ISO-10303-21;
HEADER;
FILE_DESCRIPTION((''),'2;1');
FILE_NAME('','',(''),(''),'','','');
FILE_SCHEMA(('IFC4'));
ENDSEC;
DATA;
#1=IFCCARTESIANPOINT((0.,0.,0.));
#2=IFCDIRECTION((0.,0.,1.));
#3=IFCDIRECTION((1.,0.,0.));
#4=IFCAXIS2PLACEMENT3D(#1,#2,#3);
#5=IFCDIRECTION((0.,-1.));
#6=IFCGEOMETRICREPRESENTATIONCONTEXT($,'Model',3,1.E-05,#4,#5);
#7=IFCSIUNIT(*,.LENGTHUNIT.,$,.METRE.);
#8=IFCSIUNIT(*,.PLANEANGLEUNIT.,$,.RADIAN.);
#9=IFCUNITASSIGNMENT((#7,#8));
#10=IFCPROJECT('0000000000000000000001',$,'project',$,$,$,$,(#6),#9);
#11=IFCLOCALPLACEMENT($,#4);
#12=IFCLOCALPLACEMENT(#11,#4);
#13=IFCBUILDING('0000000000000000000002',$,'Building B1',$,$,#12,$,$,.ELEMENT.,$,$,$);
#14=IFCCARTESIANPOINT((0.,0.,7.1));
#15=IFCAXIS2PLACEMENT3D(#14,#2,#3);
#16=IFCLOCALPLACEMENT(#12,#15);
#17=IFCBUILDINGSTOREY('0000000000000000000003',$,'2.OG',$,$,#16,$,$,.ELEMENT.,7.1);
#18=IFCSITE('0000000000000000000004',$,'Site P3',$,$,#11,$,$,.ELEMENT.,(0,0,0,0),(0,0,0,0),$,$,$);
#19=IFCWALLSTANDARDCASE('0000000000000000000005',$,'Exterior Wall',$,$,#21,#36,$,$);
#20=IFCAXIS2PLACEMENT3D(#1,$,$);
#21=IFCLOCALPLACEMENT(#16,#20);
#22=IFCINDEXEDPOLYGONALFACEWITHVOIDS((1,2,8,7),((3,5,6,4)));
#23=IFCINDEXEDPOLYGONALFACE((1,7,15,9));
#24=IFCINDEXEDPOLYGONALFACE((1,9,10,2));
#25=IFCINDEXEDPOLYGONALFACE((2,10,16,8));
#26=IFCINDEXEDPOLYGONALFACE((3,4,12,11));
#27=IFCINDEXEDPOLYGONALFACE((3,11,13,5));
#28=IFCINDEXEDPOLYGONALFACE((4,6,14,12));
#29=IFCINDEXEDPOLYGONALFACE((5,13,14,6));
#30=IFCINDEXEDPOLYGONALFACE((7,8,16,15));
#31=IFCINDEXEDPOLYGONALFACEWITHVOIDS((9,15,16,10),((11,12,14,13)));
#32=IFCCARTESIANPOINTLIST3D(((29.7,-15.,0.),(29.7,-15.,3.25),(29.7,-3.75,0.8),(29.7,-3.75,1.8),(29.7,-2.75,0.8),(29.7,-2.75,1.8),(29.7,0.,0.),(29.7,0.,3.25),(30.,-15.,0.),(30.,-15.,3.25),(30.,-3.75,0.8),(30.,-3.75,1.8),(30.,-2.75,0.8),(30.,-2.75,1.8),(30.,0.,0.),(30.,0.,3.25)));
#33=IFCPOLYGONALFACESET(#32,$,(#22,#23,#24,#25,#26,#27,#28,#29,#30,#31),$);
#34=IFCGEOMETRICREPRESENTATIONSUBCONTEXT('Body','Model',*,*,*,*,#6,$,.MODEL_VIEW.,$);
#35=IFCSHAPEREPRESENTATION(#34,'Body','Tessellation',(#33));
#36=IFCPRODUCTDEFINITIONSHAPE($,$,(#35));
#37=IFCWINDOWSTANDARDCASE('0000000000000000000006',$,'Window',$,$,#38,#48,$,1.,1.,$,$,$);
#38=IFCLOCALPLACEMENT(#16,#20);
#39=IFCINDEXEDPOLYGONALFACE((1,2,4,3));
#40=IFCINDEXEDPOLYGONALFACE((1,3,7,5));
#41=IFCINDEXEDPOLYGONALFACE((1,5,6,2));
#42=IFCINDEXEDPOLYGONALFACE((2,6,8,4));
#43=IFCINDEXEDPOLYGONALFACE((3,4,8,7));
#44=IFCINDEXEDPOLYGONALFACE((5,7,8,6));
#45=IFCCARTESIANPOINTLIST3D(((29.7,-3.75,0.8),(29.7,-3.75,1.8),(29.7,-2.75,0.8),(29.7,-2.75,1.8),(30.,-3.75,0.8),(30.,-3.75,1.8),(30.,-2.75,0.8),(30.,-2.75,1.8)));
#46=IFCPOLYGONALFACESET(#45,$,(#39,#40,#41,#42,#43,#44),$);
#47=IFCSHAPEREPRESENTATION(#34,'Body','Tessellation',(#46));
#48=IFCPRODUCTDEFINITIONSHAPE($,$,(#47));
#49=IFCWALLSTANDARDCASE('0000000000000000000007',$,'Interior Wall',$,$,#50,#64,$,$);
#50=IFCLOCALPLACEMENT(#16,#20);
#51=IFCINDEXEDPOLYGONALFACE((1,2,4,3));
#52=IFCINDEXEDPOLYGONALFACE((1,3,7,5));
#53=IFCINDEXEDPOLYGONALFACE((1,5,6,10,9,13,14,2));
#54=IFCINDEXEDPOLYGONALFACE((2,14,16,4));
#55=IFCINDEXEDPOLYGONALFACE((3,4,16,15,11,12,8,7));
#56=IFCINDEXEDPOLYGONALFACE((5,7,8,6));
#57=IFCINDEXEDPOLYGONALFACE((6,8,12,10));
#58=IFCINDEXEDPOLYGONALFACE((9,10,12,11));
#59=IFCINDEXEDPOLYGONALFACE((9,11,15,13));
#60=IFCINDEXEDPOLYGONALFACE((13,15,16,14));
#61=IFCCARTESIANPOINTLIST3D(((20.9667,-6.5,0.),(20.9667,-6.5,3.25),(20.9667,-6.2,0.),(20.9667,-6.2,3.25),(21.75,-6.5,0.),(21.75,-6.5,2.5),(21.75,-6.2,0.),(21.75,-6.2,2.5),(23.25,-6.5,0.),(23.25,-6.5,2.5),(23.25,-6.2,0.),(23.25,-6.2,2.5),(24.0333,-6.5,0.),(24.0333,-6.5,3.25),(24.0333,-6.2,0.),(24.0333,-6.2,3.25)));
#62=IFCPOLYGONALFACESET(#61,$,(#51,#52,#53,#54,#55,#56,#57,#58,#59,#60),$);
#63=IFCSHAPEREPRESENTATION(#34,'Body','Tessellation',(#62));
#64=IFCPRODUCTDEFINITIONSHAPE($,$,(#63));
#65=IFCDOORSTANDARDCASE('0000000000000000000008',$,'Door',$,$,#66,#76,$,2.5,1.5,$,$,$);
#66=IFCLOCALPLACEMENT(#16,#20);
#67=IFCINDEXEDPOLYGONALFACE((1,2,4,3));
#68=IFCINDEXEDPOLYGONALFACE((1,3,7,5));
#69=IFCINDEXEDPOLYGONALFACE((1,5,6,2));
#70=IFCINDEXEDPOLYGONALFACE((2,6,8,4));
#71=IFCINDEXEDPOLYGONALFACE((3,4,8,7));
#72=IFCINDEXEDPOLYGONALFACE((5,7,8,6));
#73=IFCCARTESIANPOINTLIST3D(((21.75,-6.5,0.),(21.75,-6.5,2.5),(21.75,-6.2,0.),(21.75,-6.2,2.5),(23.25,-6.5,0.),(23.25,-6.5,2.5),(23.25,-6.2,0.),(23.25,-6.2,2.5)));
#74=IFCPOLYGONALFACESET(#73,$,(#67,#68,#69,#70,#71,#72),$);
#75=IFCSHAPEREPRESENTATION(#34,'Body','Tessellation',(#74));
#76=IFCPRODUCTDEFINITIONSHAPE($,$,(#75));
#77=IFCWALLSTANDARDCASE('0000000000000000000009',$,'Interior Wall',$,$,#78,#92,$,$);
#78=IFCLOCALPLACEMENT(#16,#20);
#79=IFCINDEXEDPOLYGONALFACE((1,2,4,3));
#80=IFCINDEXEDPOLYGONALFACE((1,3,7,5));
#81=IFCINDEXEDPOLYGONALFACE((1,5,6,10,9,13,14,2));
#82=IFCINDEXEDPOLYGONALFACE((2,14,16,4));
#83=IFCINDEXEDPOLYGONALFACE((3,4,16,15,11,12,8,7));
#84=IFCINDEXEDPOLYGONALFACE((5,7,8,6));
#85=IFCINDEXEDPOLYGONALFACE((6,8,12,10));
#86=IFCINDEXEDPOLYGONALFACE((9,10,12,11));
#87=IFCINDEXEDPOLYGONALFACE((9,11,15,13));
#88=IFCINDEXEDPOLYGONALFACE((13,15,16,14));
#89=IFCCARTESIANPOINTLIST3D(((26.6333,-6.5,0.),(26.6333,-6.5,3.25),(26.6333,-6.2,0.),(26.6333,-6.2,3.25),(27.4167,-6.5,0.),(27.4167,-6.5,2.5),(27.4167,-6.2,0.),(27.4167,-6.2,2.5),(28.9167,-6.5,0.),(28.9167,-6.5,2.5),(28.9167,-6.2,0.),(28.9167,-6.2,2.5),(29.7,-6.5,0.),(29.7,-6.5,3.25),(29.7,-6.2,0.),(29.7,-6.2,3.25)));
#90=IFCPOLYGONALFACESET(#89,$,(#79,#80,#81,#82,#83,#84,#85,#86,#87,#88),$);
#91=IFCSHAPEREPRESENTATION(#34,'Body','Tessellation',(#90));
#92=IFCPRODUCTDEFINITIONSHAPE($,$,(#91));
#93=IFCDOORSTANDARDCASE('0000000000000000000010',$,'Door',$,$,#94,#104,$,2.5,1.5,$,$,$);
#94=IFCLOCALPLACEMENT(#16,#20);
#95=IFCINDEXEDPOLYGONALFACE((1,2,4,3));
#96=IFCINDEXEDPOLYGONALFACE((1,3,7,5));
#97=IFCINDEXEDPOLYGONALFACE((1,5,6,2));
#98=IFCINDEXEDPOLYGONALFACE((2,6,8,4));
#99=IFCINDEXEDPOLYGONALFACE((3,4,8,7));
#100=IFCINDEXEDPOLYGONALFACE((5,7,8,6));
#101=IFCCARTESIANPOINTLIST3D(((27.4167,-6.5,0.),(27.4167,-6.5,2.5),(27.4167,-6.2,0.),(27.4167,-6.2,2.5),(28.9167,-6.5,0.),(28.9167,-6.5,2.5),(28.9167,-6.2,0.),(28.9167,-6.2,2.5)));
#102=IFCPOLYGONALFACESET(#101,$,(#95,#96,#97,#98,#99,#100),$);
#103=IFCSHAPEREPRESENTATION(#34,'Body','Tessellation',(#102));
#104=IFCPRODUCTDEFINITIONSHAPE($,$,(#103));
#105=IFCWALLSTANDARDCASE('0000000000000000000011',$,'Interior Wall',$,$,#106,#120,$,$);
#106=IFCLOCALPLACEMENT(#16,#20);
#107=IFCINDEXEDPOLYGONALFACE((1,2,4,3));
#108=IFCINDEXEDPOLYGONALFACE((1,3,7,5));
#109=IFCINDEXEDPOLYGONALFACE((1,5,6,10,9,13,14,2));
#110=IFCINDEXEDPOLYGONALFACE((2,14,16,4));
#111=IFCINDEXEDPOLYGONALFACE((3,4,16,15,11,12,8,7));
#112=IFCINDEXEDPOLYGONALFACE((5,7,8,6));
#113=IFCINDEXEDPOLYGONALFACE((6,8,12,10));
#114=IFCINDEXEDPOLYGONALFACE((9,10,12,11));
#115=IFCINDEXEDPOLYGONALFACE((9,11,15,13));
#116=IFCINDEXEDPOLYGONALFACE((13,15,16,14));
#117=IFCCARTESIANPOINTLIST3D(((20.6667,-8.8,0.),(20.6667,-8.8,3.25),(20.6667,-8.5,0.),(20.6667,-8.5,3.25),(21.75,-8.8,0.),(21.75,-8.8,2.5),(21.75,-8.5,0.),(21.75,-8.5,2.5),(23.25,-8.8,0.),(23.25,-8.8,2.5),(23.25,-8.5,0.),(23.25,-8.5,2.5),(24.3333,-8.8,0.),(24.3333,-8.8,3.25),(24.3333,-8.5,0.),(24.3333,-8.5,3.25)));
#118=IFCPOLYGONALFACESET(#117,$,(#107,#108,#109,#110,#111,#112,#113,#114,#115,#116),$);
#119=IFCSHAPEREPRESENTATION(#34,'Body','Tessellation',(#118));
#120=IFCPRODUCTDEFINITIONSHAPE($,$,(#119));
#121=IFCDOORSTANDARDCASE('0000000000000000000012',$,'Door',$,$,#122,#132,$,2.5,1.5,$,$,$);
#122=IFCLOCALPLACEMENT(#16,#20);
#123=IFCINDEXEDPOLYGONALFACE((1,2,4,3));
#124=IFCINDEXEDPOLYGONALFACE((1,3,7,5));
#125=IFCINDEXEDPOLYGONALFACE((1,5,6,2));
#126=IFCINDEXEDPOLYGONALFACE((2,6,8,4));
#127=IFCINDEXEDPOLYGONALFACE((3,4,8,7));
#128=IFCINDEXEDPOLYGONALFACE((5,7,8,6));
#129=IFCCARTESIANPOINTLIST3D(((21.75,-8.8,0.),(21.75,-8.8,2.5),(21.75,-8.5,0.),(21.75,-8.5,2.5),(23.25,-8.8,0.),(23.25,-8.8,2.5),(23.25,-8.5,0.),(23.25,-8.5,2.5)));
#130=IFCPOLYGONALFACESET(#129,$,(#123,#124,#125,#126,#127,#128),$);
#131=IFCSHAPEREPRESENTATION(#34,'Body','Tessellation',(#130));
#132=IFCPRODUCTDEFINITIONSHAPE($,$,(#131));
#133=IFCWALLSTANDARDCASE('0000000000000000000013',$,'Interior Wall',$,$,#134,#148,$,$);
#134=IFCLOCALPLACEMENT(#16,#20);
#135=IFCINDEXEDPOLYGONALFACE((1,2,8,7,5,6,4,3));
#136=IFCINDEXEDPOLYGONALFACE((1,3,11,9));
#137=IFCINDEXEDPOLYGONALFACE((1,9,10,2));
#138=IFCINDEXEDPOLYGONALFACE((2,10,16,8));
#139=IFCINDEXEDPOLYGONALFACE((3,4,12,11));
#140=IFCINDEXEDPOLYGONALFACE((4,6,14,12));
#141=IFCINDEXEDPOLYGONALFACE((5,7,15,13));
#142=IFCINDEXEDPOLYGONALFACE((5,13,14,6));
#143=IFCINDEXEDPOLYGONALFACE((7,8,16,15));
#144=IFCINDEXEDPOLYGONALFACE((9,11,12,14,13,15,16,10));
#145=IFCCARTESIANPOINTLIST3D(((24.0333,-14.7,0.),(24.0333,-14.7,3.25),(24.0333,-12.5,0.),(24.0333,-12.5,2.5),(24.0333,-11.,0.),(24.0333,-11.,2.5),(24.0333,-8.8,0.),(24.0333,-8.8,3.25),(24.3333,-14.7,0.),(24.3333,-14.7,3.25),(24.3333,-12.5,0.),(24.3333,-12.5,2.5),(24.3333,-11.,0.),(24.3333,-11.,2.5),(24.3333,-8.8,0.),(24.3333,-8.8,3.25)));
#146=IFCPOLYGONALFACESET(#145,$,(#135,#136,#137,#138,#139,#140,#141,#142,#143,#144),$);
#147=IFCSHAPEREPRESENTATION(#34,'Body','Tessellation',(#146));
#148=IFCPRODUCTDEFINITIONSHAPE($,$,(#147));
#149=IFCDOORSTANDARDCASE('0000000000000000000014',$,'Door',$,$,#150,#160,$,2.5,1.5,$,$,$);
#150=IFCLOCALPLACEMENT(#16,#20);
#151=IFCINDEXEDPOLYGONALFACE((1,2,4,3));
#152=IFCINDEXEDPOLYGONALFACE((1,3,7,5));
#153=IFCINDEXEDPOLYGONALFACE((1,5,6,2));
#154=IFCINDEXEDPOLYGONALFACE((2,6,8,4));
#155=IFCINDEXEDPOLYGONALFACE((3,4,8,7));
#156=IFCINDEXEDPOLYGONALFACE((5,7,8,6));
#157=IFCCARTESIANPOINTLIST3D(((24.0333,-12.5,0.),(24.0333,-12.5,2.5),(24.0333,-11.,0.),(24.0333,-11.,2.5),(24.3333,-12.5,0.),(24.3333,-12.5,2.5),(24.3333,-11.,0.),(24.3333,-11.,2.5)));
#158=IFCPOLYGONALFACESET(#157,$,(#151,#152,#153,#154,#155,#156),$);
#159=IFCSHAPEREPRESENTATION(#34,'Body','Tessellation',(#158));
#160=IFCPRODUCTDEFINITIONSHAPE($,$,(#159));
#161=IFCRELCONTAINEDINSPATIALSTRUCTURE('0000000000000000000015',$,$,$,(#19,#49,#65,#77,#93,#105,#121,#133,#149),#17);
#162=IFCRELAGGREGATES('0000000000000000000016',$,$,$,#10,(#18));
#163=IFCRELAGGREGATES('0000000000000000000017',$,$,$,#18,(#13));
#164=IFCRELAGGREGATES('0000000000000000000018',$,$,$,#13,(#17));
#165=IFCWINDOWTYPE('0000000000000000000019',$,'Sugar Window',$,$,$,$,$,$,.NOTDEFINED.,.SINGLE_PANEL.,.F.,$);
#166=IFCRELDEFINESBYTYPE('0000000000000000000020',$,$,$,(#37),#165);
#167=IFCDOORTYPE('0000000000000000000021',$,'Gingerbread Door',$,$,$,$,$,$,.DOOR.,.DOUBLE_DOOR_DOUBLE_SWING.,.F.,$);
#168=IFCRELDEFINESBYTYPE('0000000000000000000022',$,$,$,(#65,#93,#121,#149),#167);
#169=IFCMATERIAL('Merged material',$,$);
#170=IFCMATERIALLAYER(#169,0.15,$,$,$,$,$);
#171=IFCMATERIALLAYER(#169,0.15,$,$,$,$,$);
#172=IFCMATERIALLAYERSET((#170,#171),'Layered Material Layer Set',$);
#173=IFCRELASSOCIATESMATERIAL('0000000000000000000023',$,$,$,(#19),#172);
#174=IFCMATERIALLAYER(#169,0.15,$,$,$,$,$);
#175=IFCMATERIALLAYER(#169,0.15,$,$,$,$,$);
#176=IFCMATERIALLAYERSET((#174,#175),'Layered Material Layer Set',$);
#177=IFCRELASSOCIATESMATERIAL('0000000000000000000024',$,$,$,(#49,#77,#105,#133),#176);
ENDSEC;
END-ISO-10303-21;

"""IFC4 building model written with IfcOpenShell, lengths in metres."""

from ifc_helpers import new_model, si_unit, direction, frame, origin_with_axes, place, context, subcontext, project, spatial, polyline, outline, extrude, source, transform, mapped, material, layer, layer_set, layer_usage, type_object, element, fill, save


model = new_model("IFC4")

# Units and contexts
model_context = context("Model", 3, precision=1e-05, world=origin_with_axes(), true_north=direction((0.0, -1.0)))
body_context = subcontext(model_context, "Body", "Model", "MODEL_VIEW")
ifc_project = project(units=[si_unit("LENGTHUNIT", "METRE"), si_unit("PLANEANGLEUNIT", "RADIAN")], contexts=[model_context])

# Site, building, storey
site_placement = place(None, origin_with_axes())
site = spatial("IfcSite", under=ifc_project, at=site_placement, Name="Site P3", CompositionType="ELEMENT", RefLatitude=(0, 0, 0, 0), RefLongitude=(0, 0, 0, 0))
building_placement = place(site_placement, origin_with_axes())
building = spatial("IfcBuilding", under=site, at=building_placement, Name="Building B1", CompositionType="ELEMENT")
storey_placement = place(building_placement, frame((0.0, 0.0, 7.1), z_axis=(0.0, 0.0, 1.0), x_axis=(1.0, 0.0, 0.0)))
storey = spatial("IfcBuildingStorey", under=building, at=storey_placement, Name="2.OG", CompositionType="ELEMENT", Elevation=7.1)

# Wall, opening, window
ifc_material = material(Name="Merged material")
ifc_layer_1 = layer(ifc_material, 0.15)
ifc_layer_2 = layer(ifc_material, 0.15)
ifc_layer_set_1 = layer_set([ifc_layer_1, ifc_layer_2], Name="Layered Material Layer Set")
ifc_layer_usage_1 = layer_usage(ifc_layer_set_1, "AXIS2", "POSITIVE", -0.15)
wall_1_placement = place(storey_placement, frame((29.85, -15.0, 0.0), z_axis=(0.0, 0.0, 1.0), x_axis=(0.0, 1.0, 0.0)))
wall_1 = element("IfcWallStandardCase", 1, at=wall_1_placement, inside=storey, material=ifc_layer_usage_1, Name="Exterior Wall", context=body_context, shape_type="SweptSolid", body=[
    extrude(outline(polyline([(0.0, 0.15), (15.0, 0.15), (15.0, -0.15), (0.0, -0.15), (0.0, 0.15)])), origin_with_axes(), (0.0, 0.0, 1.0), 3.25),
])
opening_1_placement = place(wall_1_placement, frame((11.25, 0.0, 0.8), z_axis=(0.0, 0.0, 1.0), x_axis=(1.0, 0.0, 0.0)))
opening_1 = element("IfcOpeningStandardCase", 2, at=opening_1_placement, cuts=wall_1, context=body_context, shape_type="SweptSolid", body=[
    extrude(outline(polyline([(0.0, 0.0), (0.0, 1.0), (1.0, 1.0), (1.0, 0.0), (0.0, 0.0)])), frame((0.0, -0.15, 0.0), z_axis=(0.0, 1.0, 0.0), x_axis=(0.0, 0.0, 1.0)), (0.0, 0.0, 1.0), 0.3),
])
window_type = type_object("IfcWindowType", Name="Sugar Window", ParameterTakesPrecedence=False, PartitioningType="SINGLE_PANEL", PredefinedType="NOTDEFINED")
shared_shape_1 = source(origin_with_axes(), body_context, "Body", "SweptSolid", [
    extrude(outline(polyline([(0.0, 0.0), (0.0, 1.0), (1.0, 1.0), (1.0, 0.0), (0.0, 0.0)])), frame((0.0, -0.15, 0.0), z_axis=(0.0, 1.0, 0.0), x_axis=(0.0, 0.0, 1.0)), (0.0, 0.0, 1.0), 0.3),
])
window_placement = place(opening_1_placement, origin_with_axes())
window = element("IfcWindowStandardCase", 3, at=window_placement, type_object=window_type, Name="Window", OverallHeight=1.0, OverallWidth=1.0, context=body_context, shape_type="MappedRepresentation", body=[
    mapped(shared_shape_1, transform((0.0, 0.0, 0.0))),
])
fill(opening_1, window)

# Walls, openings, doors
ifc_layer_3 = layer(ifc_material, 0.15)
ifc_layer_4 = layer(ifc_material, 0.15)
ifc_layer_set_2 = layer_set([ifc_layer_3, ifc_layer_4], Name="Layered Material Layer Set")
ifc_layer_usage_2 = layer_usage(ifc_layer_set_2, "AXIS2", "POSITIVE", -0.15)
wall_2_placement = place(storey_placement, frame((20.9667, -6.35, 0.0), z_axis=(0.0, 0.0, 1.0), x_axis=(1.0, 0.0, 0.0)))
wall_2 = element("IfcWallStandardCase", 4, at=wall_2_placement, inside=storey, material=ifc_layer_usage_2, Name="Interior Wall", context=body_context, shape_type="SweptSolid", body=[
    extrude(outline(polyline([(0.0, 0.15), (3.0667, 0.15), (3.0667, -0.15), (0.0, -0.15), (0.0, 0.15)])), origin_with_axes(), (0.0, 0.0, 1.0), 3.25),
])
opening_2_placement = place(wall_2_placement, frame((0.7833, 0.0, 0.0), z_axis=(0.0, 0.0, 1.0), x_axis=(1.0, 0.0, 0.0)))
opening_2 = element("IfcOpeningStandardCase", 5, at=opening_2_placement, cuts=wall_2, context=body_context, shape_type="SweptSolid", body=[
    extrude(outline(polyline([(0.0, 0.0), (0.0, 1.5), (2.5, 1.5), (2.5, 0.0), (0.0, 0.0)])), frame((0.0, -0.15, 0.0), z_axis=(0.0, 1.0, 0.0), x_axis=(0.0, 0.0, 1.0)), (0.0, 0.0, 1.0), 0.3),
])
door_type = type_object("IfcDoorType", Name="Gingerbread Door", OperationType="DOUBLE_DOOR_DOUBLE_SWING", ParameterTakesPrecedence=False, PredefinedType="DOOR")
shared_shape_2 = source(origin_with_axes(), body_context, "Body", "SweptSolid", [
    extrude(outline(polyline([(0.0, 0.0), (0.0, 1.5), (2.5, 1.5), (2.5, 0.0), (0.0, 0.0)])), frame((0.0, -0.15, 0.0), z_axis=(0.0, 1.0, 0.0), x_axis=(0.0, 0.0, 1.0)), (0.0, 0.0, 1.0), 0.3),
])
door_1_placement = place(opening_2_placement, origin_with_axes())
door_1 = element("IfcDoorStandardCase", 6, at=door_1_placement, inside=storey, type_object=door_type, Name="Door", OverallHeight=2.5, OverallWidth=1.5, context=body_context, shape_type="MappedRepresentation", body=[
    mapped(shared_shape_2, transform((0.0, 0.0, 0.0))),
])
fill(opening_2, door_1)
wall_3_placement = place(storey_placement, frame((26.6333, -6.35, 0.0), z_axis=(0.0, 0.0, 1.0), x_axis=(1.0, 0.0, 0.0)))
wall_3 = element("IfcWallStandardCase", 7, at=wall_3_placement, inside=storey, material=ifc_layer_usage_2, Name="Interior Wall", context=body_context, shape_type="SweptSolid", body=[
    extrude(outline(polyline([(0.0, 0.15), (3.0667, 0.15), (3.0667, -0.15), (0.0, -0.15), (0.0, 0.15)])), origin_with_axes(), (0.0, 0.0, 1.0), 3.25),
])
opening_3_placement = place(wall_3_placement, frame((0.7833, 0.0, 0.0), z_axis=(0.0, 0.0, 1.0), x_axis=(1.0, 0.0, 0.0)))
opening_3 = element("IfcOpeningStandardCase", 8, at=opening_3_placement, cuts=wall_3, context=body_context, shape_type="SweptSolid", body=[
    extrude(outline(polyline([(0.0, 0.0), (0.0, 1.5), (2.5, 1.5), (2.5, 0.0), (0.0, 0.0)])), frame((0.0, -0.15, 0.0), z_axis=(0.0, 1.0, 0.0), x_axis=(0.0, 0.0, 1.0)), (0.0, 0.0, 1.0), 0.3),
])
door_2_placement = place(opening_3_placement, origin_with_axes())
door_2 = element("IfcDoorStandardCase", 9, at=door_2_placement, inside=storey, type_object=door_type, Name="Door", OverallHeight=2.5, OverallWidth=1.5, context=body_context, shape_type="MappedRepresentation", body=[
    mapped(shared_shape_2, transform((0.0, 0.0, 0.0))),
])
fill(opening_3, door_2)
wall_4_placement = place(storey_placement, frame((20.6667, -8.65, 0.0), z_axis=(0.0, 0.0, 1.0), x_axis=(1.0, 0.0, 0.0)))
wall_4 = element("IfcWallStandardCase", 10, at=wall_4_placement, inside=storey, material=ifc_layer_usage_2, Name="Interior Wall", context=body_context, shape_type="SweptSolid", body=[
    extrude(outline(polyline([(0.0, 0.15), (3.6667, 0.15), (3.6667, -0.15), (0.0, -0.15), (0.0, 0.15)])), origin_with_axes(), (0.0, 0.0, 1.0), 3.25),
])
opening_4_placement = place(wall_4_placement, frame((1.0833, 0.0, 0.0), z_axis=(0.0, 0.0, 1.0), x_axis=(1.0, 0.0, 0.0)))
opening_4 = element("IfcOpeningStandardCase", 11, at=opening_4_placement, cuts=wall_4, context=body_context, shape_type="SweptSolid", body=[
    extrude(outline(polyline([(0.0, 0.0), (0.0, 1.5), (2.5, 1.5), (2.5, 0.0), (0.0, 0.0)])), frame((0.0, -0.15, 0.0), z_axis=(0.0, 1.0, 0.0), x_axis=(0.0, 0.0, 1.0)), (0.0, 0.0, 1.0), 0.3),
])
door_3_placement = place(opening_4_placement, origin_with_axes())
door_3 = element("IfcDoorStandardCase", 12, at=door_3_placement, inside=storey, type_object=door_type, Name="Door", OverallHeight=2.5, OverallWidth=1.5, context=body_context, shape_type="MappedRepresentation", body=[
    mapped(shared_shape_2, transform((0.0, 0.0, 0.0))),
])
fill(opening_4, door_3)
wall_5_placement = place(storey_placement, frame((24.1833, -8.8, 0.0), z_axis=(0.0, 0.0, 1.0), x_axis=(0.0, -1.0, 0.0)))
wall_5 = element("IfcWallStandardCase", 13, at=wall_5_placement, inside=storey, material=ifc_layer_usage_2, Name="Interior Wall", context=body_context, shape_type="SweptSolid", body=[
    extrude(outline(polyline([(0.0, 0.15), (5.9, 0.15), (5.9, -0.15), (0.0, -0.15), (0.0, 0.15)])), origin_with_axes(), (0.0, 0.0, 1.0), 3.25),
])
opening_5_placement = place(wall_5_placement, frame((2.2, 0.0, 0.0), z_axis=(0.0, 0.0, 1.0), x_axis=(1.0, 0.0, 0.0)))
opening_5 = element("IfcOpeningStandardCase", 14, at=opening_5_placement, cuts=wall_5, context=body_context, shape_type="SweptSolid", body=[
    extrude(outline(polyline([(0.0, 0.0), (0.0, 1.5), (2.5, 1.5), (2.5, 0.0), (0.0, 0.0)])), frame((0.0, -0.15, 0.0), z_axis=(0.0, 1.0, 0.0), x_axis=(0.0, 0.0, 1.0)), (0.0, 0.0, 1.0), 0.3),
])
door_4_placement = place(opening_5_placement, origin_with_axes())
door_4 = element("IfcDoorStandardCase", 15, at=door_4_placement, inside=storey, type_object=door_type, Name="Door", OverallHeight=2.5, OverallWidth=1.5, context=body_context, shape_type="MappedRepresentation", body=[
    mapped(shared_shape_2, transform((0.0, 0.0, 0.0))),
])
fill(opening_5, door_4)

save(model, "model.ifc")
